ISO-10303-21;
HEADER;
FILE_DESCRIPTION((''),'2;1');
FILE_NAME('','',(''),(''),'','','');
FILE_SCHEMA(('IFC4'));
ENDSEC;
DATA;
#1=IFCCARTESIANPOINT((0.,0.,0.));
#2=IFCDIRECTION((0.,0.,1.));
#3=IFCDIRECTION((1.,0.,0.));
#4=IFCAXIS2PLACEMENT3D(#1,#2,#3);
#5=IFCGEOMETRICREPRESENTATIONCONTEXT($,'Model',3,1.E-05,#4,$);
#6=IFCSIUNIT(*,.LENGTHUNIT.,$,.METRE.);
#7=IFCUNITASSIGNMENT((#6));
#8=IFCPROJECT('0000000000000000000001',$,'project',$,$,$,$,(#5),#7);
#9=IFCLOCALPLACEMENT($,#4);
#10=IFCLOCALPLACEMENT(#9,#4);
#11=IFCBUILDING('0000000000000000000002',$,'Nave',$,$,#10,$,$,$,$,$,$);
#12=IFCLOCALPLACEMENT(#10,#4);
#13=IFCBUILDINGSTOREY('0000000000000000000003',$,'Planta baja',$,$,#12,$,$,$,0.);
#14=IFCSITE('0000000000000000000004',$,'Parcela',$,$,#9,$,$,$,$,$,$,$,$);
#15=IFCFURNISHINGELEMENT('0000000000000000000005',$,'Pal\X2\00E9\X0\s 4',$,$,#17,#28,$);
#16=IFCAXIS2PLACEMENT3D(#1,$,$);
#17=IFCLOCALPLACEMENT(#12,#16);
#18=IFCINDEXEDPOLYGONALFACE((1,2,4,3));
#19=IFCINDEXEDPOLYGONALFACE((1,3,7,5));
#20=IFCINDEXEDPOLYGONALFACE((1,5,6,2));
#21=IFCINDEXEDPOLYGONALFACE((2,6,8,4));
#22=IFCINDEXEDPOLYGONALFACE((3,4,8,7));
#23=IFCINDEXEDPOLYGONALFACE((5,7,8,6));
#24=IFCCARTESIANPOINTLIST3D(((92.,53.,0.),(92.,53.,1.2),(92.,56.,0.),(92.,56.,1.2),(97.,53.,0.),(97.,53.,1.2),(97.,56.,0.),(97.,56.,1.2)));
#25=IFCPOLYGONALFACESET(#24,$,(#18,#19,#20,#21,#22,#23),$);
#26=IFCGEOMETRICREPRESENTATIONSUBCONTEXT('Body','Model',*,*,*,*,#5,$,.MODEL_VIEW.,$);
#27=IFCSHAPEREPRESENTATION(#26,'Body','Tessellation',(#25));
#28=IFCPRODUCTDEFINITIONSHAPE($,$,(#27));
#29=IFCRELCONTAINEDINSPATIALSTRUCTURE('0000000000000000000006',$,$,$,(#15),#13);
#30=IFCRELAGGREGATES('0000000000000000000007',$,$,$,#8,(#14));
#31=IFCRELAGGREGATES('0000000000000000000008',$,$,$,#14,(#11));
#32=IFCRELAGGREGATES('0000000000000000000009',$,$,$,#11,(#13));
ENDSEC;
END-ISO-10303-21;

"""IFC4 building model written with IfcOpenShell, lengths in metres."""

from ifc_helpers import new_model, si_unit, frame, origin_with_axes, place, context, subcontext, project, spatial, indexed_curve, outline, extrude, element, save


model = new_model("IFC4")

# Units and contexts
model_context = context("Model", 3, precision=1e-05, world=origin_with_axes())
body_context = subcontext(model_context, "Body", "Model", "MODEL_VIEW")
ifc_project = project(units=[si_unit("LENGTHUNIT", "METRE")], contexts=[model_context])

# Site, building, storey
site_placement = place(None, origin_with_axes())
site = spatial("IfcSite", under=ifc_project, at=site_placement, Name="Parcela")
building_placement = place(site_placement, origin_with_axes())
building = spatial("IfcBuilding", under=site, at=building_placement, Name="Nave")
storey_placement = place(building_placement, origin_with_axes())
storey = spatial("IfcBuildingStorey", under=building, at=storey_placement, Name="Planta baja", Elevation=0.0)

# Furnishing element
for number, where, z_axis, x_axis, name in (
    (1, (92.0, 53.0, 0.0), (0.0, 0.0, 1.0), (1.0, 0.0, 0.0), "Palés 4"),
):
    element("IfcFurnishingElement", number, at=place(storey_placement, frame(where, z_axis=z_axis, x_axis=x_axis)), inside=storey, Name=name, context=body_context, shape_type="SweptSolid", body=[
        extrude(outline(indexed_curve([(0.0, 0.0), (0.0, 3.0), (5.0, 3.0), (5.0, 0.0), (0.0, 0.0)], self_intersect=False)), origin_with_axes(), (0.0, 0.0, 1.0), 1.2),
    ])

save(model, "model.ifc")
